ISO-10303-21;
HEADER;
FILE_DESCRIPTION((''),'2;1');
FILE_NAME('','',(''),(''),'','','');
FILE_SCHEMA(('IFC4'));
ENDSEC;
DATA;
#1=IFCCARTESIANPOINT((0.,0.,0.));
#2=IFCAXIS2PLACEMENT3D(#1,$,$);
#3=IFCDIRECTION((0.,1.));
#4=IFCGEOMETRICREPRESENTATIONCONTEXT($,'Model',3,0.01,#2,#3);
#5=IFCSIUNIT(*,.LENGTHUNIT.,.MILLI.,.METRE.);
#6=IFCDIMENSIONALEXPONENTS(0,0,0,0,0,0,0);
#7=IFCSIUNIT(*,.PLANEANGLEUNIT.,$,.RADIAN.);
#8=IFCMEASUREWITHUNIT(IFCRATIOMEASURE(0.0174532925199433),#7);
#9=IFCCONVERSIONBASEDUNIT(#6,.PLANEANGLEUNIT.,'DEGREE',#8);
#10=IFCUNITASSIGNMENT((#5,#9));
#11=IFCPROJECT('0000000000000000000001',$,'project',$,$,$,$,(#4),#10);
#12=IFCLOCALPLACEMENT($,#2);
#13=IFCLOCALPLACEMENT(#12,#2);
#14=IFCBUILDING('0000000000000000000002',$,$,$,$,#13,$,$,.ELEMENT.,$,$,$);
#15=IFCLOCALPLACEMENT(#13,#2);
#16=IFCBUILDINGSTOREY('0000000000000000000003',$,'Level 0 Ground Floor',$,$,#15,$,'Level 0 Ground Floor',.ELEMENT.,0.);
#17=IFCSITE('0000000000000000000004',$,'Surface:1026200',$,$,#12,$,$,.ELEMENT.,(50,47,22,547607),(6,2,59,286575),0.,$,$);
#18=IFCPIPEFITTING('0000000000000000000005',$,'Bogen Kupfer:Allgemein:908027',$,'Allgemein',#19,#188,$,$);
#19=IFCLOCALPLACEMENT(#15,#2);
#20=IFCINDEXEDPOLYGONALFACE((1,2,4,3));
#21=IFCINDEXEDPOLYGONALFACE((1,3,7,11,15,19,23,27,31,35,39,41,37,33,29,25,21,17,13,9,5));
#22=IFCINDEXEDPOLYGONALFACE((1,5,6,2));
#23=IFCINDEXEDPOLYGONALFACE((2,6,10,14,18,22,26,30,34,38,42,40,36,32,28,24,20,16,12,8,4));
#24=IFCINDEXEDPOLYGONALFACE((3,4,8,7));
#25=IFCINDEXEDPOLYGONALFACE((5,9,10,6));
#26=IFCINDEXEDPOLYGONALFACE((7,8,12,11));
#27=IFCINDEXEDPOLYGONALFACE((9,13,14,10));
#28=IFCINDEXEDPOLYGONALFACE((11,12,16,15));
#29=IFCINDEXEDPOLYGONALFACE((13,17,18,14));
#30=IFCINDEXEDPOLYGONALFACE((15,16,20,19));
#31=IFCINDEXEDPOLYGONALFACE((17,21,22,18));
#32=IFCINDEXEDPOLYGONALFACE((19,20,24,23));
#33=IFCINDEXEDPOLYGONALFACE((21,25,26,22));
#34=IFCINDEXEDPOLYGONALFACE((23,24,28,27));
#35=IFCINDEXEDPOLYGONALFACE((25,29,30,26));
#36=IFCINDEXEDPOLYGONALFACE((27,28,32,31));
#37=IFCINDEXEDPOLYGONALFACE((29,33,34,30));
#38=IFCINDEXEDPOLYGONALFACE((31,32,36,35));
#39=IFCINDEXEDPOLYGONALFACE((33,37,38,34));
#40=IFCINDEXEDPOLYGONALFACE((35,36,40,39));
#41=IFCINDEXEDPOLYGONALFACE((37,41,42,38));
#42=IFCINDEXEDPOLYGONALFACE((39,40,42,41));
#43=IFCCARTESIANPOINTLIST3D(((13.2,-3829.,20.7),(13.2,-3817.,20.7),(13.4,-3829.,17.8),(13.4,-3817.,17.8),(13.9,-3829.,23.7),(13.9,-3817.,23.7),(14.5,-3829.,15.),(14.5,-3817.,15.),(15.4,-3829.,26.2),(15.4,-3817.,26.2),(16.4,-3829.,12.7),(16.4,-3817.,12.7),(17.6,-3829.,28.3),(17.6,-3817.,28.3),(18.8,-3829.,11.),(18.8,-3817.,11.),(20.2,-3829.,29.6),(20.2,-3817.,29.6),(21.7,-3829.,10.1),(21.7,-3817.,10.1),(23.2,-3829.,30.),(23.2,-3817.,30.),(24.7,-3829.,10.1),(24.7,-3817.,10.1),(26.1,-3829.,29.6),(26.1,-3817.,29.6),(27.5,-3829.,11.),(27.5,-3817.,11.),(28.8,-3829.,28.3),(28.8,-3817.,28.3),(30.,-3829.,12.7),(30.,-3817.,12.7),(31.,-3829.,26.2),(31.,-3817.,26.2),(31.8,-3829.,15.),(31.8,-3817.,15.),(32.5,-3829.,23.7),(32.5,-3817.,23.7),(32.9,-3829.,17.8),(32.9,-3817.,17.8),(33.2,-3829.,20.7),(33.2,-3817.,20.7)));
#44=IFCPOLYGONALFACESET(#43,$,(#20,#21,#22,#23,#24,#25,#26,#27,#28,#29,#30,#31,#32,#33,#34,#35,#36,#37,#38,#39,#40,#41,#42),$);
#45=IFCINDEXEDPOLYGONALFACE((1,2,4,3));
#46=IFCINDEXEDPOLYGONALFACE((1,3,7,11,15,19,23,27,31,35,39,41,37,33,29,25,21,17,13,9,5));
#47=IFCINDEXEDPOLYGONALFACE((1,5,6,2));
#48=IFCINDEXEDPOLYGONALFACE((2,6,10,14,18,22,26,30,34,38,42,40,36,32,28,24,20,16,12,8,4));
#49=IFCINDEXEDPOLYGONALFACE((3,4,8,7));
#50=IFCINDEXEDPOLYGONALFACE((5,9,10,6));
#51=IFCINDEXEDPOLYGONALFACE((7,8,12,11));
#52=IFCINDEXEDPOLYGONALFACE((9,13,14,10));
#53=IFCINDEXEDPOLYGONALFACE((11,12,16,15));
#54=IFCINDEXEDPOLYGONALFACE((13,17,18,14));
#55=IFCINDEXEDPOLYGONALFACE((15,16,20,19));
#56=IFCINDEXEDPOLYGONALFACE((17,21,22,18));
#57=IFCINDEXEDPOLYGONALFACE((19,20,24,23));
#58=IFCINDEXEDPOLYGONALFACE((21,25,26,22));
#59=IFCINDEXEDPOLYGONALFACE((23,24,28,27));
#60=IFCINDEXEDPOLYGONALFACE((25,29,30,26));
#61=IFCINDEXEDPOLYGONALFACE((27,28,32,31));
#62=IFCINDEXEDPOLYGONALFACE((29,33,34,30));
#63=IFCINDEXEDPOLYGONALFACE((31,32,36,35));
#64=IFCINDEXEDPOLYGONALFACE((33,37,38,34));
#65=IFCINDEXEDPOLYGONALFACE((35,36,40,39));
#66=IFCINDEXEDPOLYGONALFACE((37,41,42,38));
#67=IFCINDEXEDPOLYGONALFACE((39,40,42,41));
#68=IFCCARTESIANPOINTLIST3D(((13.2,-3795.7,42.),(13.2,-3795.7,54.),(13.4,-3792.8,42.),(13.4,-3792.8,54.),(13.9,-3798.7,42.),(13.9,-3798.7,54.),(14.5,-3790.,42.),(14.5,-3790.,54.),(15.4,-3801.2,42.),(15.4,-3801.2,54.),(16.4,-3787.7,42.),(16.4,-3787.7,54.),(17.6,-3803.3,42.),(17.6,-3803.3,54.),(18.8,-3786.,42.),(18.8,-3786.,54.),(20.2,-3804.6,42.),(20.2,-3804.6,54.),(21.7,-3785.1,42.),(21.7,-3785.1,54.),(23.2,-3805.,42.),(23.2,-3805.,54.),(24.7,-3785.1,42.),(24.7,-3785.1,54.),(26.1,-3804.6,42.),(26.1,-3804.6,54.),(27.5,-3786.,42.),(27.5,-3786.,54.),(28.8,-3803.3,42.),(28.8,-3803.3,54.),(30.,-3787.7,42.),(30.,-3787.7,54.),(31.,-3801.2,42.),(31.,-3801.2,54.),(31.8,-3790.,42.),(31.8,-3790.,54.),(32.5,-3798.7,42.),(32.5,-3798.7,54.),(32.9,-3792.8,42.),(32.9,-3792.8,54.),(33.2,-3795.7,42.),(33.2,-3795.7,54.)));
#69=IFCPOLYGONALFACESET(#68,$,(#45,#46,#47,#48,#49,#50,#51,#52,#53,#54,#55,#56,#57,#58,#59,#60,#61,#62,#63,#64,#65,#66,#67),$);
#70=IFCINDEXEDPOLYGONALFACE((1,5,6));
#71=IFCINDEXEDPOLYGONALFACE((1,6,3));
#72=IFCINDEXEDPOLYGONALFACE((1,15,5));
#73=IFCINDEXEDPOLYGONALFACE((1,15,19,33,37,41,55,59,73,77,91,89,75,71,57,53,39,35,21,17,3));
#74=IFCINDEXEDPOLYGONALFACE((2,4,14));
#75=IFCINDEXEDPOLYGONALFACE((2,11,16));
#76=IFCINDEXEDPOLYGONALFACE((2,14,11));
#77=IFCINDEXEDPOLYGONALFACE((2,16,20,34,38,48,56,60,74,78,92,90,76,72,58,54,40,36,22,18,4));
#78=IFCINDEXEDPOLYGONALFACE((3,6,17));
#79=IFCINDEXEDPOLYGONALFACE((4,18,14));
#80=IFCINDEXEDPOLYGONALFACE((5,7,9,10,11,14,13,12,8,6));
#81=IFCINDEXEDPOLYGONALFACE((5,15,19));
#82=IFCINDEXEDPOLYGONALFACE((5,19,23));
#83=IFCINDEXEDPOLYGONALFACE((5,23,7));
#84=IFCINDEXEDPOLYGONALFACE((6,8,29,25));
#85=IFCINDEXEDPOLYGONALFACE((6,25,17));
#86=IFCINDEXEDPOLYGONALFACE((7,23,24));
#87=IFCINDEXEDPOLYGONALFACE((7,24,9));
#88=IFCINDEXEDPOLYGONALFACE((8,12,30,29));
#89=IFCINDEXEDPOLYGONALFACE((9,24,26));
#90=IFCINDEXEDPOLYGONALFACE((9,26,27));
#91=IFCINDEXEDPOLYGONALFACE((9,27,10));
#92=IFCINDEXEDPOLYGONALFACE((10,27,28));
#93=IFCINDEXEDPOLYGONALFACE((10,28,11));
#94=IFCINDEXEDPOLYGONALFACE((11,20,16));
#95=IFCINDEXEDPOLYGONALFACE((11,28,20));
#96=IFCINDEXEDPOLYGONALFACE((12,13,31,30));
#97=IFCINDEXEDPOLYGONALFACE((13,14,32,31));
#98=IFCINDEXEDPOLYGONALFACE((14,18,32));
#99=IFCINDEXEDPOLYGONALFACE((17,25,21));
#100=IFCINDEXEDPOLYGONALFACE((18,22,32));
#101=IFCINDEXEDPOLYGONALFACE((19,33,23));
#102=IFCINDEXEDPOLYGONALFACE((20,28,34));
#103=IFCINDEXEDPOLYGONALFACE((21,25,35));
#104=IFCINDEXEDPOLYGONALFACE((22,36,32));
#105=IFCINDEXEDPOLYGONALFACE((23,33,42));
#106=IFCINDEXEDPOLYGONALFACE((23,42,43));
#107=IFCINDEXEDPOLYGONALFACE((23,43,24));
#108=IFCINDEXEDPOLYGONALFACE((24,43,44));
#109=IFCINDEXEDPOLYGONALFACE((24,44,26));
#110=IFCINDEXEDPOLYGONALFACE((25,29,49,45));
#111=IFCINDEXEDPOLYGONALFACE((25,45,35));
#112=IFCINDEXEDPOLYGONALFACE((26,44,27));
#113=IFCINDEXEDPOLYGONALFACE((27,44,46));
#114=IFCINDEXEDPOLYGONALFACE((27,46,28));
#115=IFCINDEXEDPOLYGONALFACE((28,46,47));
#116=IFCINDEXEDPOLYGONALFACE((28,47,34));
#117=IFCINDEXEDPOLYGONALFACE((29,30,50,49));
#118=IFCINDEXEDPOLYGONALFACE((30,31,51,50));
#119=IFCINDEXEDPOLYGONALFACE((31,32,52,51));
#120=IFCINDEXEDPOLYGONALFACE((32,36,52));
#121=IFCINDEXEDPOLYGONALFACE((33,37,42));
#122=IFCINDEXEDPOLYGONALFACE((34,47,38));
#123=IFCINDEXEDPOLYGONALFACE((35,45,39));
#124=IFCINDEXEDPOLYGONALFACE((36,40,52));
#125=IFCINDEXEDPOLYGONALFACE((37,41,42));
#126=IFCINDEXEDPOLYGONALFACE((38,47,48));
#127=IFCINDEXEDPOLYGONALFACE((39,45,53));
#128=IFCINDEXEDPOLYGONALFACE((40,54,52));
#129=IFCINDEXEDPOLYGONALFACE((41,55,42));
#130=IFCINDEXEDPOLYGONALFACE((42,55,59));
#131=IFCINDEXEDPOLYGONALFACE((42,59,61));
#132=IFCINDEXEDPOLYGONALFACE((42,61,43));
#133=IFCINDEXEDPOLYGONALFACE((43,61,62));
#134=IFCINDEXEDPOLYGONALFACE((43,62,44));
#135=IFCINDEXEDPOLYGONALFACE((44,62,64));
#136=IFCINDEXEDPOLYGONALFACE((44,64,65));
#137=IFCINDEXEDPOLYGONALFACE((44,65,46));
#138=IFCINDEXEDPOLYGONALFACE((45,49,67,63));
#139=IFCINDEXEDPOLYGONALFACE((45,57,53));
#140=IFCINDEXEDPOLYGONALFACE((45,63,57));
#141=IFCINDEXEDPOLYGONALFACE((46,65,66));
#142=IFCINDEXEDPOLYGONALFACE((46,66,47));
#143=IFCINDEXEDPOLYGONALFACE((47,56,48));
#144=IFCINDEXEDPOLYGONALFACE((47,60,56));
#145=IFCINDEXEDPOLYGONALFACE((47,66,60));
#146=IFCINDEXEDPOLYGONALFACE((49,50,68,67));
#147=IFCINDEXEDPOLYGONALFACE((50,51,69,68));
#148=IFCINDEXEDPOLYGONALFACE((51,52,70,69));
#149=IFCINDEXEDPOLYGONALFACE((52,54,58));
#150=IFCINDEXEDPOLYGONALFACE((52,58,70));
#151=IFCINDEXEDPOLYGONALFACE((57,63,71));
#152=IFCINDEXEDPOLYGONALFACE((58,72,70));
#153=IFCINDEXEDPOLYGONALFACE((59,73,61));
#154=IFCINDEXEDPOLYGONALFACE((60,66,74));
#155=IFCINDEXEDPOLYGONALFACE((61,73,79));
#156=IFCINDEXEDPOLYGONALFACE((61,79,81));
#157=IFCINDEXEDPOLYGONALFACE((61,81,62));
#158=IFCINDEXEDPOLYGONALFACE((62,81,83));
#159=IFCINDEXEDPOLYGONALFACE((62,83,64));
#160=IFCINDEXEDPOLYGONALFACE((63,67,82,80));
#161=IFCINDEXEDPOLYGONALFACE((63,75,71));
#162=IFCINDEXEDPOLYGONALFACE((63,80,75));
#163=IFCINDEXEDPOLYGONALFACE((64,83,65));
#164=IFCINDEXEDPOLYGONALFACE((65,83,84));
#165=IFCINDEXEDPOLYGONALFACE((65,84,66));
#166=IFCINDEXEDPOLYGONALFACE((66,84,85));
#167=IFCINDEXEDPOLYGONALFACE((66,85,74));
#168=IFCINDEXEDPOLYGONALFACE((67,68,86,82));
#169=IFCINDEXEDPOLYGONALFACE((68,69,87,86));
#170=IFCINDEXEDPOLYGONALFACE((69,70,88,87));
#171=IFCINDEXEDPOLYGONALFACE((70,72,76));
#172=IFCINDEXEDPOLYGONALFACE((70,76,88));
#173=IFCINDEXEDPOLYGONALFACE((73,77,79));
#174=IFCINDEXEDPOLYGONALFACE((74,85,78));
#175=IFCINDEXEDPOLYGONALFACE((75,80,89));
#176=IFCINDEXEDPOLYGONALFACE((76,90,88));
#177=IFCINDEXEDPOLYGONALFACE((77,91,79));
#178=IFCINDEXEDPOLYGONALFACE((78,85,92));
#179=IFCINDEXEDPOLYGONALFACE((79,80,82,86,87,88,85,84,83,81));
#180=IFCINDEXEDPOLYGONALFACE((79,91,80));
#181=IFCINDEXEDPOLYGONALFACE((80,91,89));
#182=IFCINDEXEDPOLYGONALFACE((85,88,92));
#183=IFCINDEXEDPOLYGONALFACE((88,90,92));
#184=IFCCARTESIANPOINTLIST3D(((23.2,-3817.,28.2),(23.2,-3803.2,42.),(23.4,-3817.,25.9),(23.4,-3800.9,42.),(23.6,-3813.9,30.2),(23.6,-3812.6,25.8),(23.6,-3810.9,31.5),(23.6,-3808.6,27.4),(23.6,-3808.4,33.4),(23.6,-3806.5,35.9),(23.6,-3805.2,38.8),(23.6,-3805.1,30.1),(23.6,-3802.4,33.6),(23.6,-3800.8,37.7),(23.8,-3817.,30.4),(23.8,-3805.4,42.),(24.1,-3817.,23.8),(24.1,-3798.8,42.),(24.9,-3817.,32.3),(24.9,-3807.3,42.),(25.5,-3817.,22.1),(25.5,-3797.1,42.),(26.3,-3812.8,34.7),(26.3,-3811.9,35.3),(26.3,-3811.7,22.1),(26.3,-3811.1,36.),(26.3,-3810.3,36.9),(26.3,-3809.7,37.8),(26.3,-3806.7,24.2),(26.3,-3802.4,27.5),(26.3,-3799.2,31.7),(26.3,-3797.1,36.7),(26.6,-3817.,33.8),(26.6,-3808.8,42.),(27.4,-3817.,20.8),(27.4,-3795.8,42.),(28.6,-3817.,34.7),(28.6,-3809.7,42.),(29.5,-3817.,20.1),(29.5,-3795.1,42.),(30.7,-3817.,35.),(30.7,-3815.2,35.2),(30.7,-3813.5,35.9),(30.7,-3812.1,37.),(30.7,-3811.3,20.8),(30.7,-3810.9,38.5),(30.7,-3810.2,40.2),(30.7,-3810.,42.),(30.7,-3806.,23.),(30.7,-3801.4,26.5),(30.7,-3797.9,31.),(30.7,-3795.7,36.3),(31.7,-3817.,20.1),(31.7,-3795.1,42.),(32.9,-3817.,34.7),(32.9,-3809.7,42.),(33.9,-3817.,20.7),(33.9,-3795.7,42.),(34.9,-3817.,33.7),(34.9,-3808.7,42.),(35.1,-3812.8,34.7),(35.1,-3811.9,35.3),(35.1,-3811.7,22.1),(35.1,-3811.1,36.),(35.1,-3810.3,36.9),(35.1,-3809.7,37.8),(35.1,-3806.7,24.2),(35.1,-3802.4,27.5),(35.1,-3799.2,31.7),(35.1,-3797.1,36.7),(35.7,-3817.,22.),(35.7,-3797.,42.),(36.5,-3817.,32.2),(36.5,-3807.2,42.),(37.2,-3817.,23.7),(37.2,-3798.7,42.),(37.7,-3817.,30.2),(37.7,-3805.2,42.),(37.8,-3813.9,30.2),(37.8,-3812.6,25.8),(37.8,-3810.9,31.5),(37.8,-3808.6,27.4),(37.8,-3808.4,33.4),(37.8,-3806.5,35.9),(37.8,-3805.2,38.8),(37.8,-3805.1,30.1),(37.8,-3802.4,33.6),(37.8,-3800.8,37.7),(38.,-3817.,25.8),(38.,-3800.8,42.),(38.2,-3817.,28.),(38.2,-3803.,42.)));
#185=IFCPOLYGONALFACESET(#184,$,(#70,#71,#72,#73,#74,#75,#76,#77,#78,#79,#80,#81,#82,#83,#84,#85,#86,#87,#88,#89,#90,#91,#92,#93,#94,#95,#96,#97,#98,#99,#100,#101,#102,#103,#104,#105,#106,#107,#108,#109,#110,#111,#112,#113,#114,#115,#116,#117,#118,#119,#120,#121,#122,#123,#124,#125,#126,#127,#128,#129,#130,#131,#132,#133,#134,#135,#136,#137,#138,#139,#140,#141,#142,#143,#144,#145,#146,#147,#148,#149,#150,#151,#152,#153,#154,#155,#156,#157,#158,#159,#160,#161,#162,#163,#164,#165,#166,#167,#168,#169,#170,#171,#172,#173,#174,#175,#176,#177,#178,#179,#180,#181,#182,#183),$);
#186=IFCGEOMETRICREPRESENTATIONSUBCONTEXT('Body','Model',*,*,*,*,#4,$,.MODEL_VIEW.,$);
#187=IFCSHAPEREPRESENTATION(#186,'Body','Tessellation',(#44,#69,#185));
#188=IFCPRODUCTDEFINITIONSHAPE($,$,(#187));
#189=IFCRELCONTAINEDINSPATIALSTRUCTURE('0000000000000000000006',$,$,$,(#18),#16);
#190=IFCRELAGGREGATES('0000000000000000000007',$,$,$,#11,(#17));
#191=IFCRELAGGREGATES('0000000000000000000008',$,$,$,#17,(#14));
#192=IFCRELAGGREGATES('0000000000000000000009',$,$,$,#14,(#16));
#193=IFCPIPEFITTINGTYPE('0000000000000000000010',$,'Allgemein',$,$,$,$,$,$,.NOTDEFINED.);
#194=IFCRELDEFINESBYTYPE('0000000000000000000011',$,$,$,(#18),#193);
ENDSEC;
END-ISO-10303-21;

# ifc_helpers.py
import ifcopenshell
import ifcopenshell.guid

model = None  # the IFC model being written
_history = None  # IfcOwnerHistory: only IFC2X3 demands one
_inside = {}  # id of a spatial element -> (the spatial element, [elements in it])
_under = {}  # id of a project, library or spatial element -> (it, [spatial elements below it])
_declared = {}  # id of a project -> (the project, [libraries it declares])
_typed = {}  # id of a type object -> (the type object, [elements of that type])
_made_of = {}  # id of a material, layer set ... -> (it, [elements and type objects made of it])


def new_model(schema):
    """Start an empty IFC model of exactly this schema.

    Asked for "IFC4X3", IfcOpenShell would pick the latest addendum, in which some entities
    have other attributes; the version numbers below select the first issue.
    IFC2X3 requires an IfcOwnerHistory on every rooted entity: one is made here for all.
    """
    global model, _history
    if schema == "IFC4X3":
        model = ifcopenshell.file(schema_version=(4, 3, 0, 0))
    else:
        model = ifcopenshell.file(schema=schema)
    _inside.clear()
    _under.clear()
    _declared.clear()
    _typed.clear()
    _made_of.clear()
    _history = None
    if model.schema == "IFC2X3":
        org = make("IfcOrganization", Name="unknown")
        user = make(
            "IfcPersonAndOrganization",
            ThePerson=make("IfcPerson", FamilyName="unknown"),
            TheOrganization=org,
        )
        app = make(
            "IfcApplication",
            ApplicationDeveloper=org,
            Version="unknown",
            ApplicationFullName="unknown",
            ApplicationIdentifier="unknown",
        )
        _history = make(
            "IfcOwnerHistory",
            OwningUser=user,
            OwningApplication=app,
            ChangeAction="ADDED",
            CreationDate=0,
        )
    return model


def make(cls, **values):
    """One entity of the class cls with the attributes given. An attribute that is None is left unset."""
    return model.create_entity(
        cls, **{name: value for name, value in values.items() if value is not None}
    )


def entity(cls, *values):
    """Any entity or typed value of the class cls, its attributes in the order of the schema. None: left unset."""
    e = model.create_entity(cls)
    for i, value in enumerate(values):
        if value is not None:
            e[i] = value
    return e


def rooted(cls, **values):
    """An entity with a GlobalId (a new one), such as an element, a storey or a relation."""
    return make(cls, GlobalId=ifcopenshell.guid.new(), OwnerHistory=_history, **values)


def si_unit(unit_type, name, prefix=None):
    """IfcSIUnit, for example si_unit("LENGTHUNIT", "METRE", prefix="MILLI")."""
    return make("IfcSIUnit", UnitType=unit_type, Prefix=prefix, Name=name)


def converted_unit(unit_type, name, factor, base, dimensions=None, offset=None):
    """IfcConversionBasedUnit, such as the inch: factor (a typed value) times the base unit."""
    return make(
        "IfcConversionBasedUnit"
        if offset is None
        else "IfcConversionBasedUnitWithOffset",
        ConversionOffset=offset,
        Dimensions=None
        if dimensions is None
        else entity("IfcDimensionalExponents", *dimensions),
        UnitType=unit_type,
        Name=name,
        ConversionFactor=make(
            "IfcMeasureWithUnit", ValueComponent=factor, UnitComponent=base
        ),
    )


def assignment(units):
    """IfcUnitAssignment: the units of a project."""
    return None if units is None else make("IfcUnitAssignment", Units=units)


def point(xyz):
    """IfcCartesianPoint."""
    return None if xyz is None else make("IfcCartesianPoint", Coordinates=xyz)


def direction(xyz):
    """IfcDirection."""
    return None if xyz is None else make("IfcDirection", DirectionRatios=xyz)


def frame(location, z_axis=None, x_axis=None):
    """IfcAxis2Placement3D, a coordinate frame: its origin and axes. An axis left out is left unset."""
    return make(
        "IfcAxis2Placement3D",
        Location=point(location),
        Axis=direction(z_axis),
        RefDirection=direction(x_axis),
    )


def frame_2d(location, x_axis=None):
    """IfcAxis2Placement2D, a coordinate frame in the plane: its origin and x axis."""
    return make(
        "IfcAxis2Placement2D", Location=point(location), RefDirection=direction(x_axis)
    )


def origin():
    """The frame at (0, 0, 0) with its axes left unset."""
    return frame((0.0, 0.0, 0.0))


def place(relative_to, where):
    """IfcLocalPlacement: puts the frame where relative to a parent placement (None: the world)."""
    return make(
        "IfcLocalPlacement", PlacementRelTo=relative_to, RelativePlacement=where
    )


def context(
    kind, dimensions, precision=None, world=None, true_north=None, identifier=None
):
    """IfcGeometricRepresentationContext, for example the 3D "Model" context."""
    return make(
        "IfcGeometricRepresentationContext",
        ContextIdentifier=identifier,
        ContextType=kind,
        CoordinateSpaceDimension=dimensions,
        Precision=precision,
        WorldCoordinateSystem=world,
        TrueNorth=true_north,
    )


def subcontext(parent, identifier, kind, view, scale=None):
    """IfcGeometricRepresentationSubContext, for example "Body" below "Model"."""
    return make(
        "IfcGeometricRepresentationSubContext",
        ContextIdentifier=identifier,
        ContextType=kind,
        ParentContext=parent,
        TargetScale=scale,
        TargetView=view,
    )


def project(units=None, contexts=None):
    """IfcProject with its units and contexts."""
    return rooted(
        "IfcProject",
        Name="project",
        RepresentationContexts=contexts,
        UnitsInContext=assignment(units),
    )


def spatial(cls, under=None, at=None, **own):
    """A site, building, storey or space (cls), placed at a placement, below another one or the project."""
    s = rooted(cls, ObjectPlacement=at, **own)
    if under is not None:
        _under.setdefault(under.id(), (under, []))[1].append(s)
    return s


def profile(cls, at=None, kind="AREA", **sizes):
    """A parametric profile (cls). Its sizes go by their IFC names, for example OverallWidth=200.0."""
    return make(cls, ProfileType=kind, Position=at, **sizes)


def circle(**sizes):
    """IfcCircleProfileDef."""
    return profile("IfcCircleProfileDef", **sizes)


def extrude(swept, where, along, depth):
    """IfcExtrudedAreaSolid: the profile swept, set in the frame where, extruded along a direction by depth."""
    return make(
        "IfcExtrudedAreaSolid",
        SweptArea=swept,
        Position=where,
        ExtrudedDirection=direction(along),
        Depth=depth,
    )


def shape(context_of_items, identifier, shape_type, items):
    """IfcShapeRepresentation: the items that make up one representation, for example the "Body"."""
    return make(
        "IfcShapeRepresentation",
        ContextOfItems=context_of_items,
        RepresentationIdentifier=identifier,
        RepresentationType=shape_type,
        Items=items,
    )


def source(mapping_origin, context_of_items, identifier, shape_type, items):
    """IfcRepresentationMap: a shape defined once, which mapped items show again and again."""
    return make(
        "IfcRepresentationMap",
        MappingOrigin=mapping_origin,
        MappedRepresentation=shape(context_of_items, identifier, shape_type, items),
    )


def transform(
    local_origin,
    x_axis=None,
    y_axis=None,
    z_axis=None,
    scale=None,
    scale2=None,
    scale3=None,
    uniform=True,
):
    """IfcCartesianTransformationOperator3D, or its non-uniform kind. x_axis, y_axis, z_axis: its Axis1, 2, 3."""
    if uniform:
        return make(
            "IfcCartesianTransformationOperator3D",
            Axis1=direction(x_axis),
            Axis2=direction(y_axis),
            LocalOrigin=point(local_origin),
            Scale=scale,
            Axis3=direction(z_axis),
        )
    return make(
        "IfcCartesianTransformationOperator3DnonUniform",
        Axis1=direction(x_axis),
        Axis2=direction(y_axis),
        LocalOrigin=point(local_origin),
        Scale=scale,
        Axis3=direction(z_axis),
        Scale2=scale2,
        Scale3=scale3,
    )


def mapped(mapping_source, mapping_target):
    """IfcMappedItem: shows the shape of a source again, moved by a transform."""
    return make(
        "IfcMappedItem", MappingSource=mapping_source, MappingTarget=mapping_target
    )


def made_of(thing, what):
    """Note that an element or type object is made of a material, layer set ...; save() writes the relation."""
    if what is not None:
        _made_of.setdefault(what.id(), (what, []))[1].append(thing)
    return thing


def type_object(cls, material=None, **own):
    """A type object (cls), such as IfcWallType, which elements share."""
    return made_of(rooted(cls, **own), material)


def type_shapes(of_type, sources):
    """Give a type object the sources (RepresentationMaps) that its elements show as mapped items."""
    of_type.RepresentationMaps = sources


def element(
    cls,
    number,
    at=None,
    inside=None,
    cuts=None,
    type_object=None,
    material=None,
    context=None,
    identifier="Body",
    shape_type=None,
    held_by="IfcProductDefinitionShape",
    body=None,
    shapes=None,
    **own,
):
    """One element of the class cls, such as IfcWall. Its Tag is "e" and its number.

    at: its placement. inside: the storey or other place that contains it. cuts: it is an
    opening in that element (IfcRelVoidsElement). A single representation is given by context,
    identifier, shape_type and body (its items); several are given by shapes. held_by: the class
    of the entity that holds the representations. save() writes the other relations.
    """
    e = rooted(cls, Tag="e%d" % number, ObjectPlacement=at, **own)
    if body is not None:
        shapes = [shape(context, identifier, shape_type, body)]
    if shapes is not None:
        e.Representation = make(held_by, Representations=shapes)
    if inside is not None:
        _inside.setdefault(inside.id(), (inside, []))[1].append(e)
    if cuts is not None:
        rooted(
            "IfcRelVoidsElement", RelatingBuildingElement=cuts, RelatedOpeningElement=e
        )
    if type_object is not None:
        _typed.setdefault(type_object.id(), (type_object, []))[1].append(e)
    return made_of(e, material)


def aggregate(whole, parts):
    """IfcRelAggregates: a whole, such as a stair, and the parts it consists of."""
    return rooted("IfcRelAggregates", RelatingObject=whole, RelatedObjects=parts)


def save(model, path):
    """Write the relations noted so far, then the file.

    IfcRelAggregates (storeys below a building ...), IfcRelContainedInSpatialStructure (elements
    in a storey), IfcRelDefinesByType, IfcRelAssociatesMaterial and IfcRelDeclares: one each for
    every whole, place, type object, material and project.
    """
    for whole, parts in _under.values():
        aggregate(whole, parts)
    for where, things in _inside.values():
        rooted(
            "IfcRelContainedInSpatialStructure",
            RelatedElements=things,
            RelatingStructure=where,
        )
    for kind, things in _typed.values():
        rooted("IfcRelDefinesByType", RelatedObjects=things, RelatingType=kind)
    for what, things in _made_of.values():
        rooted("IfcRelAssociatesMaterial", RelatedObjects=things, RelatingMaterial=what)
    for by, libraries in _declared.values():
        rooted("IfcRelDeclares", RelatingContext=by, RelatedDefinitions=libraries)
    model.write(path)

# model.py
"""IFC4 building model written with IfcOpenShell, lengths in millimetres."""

from ifc_helpers import new_model, entity, si_unit, converted_unit, direction, frame, frame_2d, origin, place, context, subcontext, project, spatial, circle, extrude, source, transform, mapped, type_object, type_shapes, element, save


model = new_model("IFC4")

# Units and contexts
model_context = context("Model", 3, precision=0.01, world=origin(), true_north=direction((0.0, 1.0)))
body_context = subcontext(model_context, "Body", "Model", "MODEL_VIEW")
ifc_project = project(units=[si_unit("LENGTHUNIT", "METRE", prefix="MILLI"), converted_unit("PLANEANGLEUNIT", "DEGREE", entity("IfcRatioMeasure", 0.0174532925199433), si_unit("PLANEANGLEUNIT", "RADIAN"), dimensions=[0, 0, 0, 0, 0, 0, 0])], contexts=[model_context])

# Site, building, storey
site_placement = place(None, origin())
site = spatial("IfcSite", under=ifc_project, at=site_placement, Name="Surface:1026200", CompositionType="ELEMENT", RefLatitude=(50, 47, 22, 547607), RefLongitude=(6, 2, 59, 286575), RefElevation=0.0)
building_placement = place(site_placement, origin())
building = spatial("IfcBuilding", under=site, at=building_placement, CompositionType="ELEMENT")
storey_placement = place(building_placement, origin())
storey = spatial("IfcBuildingStorey", under=building, at=storey_placement, Name="Level 0 Ground Floor", LongName="Level 0 Ground Floor", CompositionType="ELEMENT", Elevation=0.0)

# Pipe fitting
pipe_fitting_type = type_object("IfcPipeFittingType", Name="Allgemein", PredefinedType="NOTDEFINED")
ifc_direction = entity("IfcDirection", [0.0, 0.0, -1.0])
trimmed_curve = entity("IfcTrimmedCurve", entity("IfcCircle", entity("IfcAxis2Placement2D", entity("IfcCartesianPoint", [-14.5, 0.0]), entity("IfcDirection", [0.0, 1.0])), 14.5), [entity("IfcParameterValue", 270.0)], [entity("IfcParameterValue", 0.0)], True, "PARAMETER")
shared_shape_1 = source(origin(), body_context, "Body", "SolidModel", [
    extrude(circle(Radius=10.0, at=frame_2d((0.0, 0.0), x_axis=(1.0, 0.0))), frame((0.0, 22.0, 0.0), z_axis=(0.0, 1.0, 0.0), x_axis=(-1.0, 0.0, 0.0)), (0.0, 0.0, 1.0), 12.0),
    extrude(circle(Radius=10.0, at=frame_2d((0.0, 0.0), x_axis=(1.0, 0.0))), frame((-34.0, 0.0, 0.0), z_axis=(1.0, 0.0, 0.0), x_axis=(0.0, 1.0, 0.0)), (0.0, 0.0, 1.0), 12.0),
    entity("IfcSurfaceCurveSweptAreaSolid", entity("IfcCircleProfileDef", "AREA", None, entity("IfcAxis2Placement2D", entity("IfcCartesianPoint", [0.0, 7.5]), entity("IfcDirection", [1.0, 0.0])), 7.5), entity("IfcAxis2Placement3D", entity("IfcCartesianPoint", [-7.5, 22.0, 0.0]), ifc_direction, entity("IfcDirection", [1.0, 0.0, 0.0])), trimmed_curve, 0.0, 90.0, entity("IfcSurfaceOfLinearExtrusion", entity("IfcArbitraryOpenProfileDef", "CURVE", None, trimmed_curve), entity("IfcAxis2Placement3D", entity("IfcCartesianPoint", [0.0, 0.0, -304.8])), ifc_direction, 1.0)),
])
type_shapes(pipe_fitting_type, [shared_shape_1])
pipe_fitting_1_placement = place(storey_placement, frame((23.2, -3795.0, 20.0), z_axis=(-1.0, 0.0, 0.0), x_axis=(0.0, 0.0, -1.0)))
element("IfcPipeFitting", 1, at=pipe_fitting_1_placement, inside=storey, type_object=pipe_fitting_type, Name="Bogen Kupfer:Allgemein:908027", ObjectType="Allgemein", context=body_context, shape_type="MappedRepresentation", body=[
    mapped(shared_shape_1, transform((0.0, 0.0, 0.0), scale=1.0)),
])

save(model, "model.ifc")
